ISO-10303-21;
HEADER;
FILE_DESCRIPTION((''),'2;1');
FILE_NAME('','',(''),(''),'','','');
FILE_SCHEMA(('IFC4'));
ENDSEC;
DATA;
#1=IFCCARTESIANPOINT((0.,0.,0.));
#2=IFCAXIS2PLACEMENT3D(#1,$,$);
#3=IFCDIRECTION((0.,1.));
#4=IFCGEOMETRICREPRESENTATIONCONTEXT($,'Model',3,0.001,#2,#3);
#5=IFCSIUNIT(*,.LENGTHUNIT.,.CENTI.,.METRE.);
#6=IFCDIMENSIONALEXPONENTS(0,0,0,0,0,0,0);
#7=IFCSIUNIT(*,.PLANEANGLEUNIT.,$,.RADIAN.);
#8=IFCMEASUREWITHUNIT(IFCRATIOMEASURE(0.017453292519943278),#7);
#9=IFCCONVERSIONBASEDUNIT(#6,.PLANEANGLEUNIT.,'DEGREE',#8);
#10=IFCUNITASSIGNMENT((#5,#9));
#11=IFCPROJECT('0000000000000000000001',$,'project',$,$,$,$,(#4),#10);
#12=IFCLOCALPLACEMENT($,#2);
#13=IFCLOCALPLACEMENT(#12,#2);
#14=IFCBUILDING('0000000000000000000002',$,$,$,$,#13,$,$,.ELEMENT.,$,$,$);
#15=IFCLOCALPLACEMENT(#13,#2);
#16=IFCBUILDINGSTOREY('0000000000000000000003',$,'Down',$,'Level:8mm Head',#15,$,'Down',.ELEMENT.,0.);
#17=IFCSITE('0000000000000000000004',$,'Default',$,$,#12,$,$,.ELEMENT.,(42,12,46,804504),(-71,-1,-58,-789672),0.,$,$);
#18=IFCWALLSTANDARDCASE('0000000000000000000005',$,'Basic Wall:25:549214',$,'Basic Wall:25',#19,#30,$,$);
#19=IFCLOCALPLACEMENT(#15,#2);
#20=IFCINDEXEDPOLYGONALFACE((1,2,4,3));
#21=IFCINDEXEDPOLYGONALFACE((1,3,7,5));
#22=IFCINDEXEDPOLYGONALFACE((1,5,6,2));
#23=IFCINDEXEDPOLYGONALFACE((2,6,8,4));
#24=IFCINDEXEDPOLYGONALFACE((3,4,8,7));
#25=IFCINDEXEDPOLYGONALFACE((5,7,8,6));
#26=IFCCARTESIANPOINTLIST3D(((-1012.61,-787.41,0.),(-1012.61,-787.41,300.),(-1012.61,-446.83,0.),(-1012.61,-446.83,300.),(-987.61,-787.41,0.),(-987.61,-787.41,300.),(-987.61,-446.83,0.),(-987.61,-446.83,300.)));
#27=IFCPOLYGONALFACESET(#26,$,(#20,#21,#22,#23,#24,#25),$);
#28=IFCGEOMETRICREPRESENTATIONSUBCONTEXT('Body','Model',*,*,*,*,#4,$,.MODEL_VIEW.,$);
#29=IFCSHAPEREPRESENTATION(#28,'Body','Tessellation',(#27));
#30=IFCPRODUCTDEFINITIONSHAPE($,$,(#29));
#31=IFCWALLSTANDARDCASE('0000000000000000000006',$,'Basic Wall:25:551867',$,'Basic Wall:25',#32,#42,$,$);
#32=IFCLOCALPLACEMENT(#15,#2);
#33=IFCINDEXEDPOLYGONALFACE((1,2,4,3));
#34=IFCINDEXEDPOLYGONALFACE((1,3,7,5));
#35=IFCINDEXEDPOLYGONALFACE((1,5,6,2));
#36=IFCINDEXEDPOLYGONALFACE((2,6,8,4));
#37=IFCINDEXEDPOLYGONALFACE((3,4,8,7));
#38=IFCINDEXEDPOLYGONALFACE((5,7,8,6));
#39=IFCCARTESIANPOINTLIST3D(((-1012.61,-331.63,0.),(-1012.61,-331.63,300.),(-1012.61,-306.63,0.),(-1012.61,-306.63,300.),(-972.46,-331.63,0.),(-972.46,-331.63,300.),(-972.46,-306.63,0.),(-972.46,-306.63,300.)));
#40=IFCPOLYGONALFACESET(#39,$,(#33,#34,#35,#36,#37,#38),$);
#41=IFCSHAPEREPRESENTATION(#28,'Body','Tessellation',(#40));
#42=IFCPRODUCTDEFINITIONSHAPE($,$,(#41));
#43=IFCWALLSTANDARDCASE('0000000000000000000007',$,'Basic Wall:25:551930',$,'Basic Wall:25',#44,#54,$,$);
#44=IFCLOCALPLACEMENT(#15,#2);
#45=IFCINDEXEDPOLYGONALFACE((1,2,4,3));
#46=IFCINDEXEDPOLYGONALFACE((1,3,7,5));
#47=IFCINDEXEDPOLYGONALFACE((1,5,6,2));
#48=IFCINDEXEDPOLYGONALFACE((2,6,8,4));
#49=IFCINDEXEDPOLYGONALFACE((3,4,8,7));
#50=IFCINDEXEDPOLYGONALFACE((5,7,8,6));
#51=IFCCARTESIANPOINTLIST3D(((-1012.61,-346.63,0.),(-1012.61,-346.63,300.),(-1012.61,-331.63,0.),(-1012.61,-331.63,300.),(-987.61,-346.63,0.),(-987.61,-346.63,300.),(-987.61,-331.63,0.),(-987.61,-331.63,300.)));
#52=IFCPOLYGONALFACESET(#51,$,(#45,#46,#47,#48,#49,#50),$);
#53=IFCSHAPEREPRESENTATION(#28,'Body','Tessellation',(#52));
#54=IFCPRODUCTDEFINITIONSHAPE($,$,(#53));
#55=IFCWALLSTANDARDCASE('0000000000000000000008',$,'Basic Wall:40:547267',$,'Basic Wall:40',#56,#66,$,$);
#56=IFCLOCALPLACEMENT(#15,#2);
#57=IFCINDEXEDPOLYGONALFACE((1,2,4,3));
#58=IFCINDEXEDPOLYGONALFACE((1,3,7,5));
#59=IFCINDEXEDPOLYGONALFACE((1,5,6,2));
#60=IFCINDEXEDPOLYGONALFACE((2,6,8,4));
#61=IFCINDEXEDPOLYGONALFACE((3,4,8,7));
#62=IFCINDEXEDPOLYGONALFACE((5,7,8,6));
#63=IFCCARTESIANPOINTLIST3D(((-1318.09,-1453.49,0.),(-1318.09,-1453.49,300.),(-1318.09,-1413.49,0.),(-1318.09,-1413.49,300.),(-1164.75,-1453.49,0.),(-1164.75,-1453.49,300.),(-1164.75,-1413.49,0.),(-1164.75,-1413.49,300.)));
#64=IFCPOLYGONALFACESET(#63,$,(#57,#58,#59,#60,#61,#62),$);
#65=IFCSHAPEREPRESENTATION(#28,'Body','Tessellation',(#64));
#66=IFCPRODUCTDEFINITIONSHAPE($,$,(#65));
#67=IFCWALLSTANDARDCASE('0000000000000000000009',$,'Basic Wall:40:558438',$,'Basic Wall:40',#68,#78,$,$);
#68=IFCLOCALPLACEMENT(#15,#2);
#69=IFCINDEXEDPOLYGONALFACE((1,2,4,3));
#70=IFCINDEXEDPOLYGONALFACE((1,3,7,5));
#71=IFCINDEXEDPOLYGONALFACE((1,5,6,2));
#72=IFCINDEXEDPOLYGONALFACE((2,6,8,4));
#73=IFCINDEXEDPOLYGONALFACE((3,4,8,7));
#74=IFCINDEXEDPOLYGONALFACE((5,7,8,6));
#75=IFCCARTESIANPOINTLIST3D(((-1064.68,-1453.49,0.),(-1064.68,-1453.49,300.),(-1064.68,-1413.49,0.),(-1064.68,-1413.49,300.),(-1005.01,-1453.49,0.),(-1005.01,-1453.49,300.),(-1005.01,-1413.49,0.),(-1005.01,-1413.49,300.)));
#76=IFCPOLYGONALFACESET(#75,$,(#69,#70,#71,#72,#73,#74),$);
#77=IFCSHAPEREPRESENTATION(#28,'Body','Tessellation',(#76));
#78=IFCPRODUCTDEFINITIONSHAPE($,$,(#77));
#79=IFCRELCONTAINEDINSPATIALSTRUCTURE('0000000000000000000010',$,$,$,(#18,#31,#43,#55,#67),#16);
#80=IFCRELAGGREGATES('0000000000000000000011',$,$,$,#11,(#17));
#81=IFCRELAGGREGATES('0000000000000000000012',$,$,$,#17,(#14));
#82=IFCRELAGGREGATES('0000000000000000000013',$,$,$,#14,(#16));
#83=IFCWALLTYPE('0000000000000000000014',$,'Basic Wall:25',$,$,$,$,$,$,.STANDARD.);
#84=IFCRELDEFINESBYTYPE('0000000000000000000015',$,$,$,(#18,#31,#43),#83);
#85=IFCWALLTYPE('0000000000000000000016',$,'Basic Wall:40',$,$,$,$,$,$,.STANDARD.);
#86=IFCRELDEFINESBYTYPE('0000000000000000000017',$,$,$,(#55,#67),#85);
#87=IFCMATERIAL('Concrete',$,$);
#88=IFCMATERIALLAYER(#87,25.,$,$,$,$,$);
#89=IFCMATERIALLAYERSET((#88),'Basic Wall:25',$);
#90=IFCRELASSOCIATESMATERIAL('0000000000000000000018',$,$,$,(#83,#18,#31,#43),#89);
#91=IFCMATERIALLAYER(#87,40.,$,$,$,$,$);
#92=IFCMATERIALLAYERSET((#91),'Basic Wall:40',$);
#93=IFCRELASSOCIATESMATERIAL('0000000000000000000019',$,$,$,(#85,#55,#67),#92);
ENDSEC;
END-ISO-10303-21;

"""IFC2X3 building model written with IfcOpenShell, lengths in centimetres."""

from ifc_helpers import new_model, entity, si_unit, converted_unit, direction, frame, frame_2d, origin, place, context, subcontext, project, spatial, rectangle, extrude, material, layer, layer_set, layer_usage, type_object, element, save


model = new_model("IFC2X3")

# Units and contexts
model_context = context("Model", 3, precision=0.001, world=origin(), true_north=direction((0.0, 1.0)))
body_context = subcontext(model_context, "Body", "Model", "MODEL_VIEW")
ifc_project = project(units=[si_unit("LENGTHUNIT", "METRE", prefix="CENTI"), converted_unit("PLANEANGLEUNIT", "DEGREE", entity("IfcRatioMeasure", 0.017453292519943278), si_unit("PLANEANGLEUNIT", "RADIAN"), dimensions=[0, 0, 0, 0, 0, 0, 0])], contexts=[model_context])

# Site, building, storey
site_placement = place(None, origin())
site = spatial("IfcSite", under=ifc_project, at=site_placement, Name="Default", CompositionType="ELEMENT", RefLatitude=(42, 12, 46, 804504), RefLongitude=(-71, -1, -58, -789672), RefElevation=0.0)
building_placement = place(site_placement, origin())
building = spatial("IfcBuilding", under=site, at=building_placement, CompositionType="ELEMENT")
storey_placement = place(building_placement, origin())
storey = spatial("IfcBuildingStorey", under=building, at=storey_placement, Name="Down", ObjectType="Level:8mm Head", LongName="Down", CompositionType="ELEMENT", Elevation=0.0)

# Walls
ifc_material = material(Name="Concrete")
ifc_layer_1 = layer(ifc_material, 25.0)
ifc_layer_set_1 = layer_set([ifc_layer_1], Name="Basic Wall:25")
wall_type_1 = type_object("IfcWallType", Name="Basic Wall:25", PredefinedType="STANDARD", material=ifc_layer_set_1)
ifc_layer_usage_1 = layer_usage(ifc_layer_set_1, "AXIS2", "POSITIVE", -12.5)
wall_1_placement = place(storey_placement, frame((-1000.11, -787.41, 0.0), z_axis=(0.0, 0.0, 1.0), x_axis=(0.0, 1.0, 0.0)))
element("IfcWallStandardCase", 1, at=wall_1_placement, inside=storey, type_object=wall_type_1, material=ifc_layer_usage_1, Name="Basic Wall:25:549214", ObjectType="Basic Wall:25", context=body_context, shape_type="SweptSolid", body=[
    extrude(rectangle(XDim=340.58, YDim=25.0, at=frame_2d((170.29, 0.0), x_axis=(-1.0, 0.0))), origin(), (0.0, 0.0, 1.0), 300.0),
])
ifc_layer_usage_2 = layer_usage(ifc_layer_set_1, "AXIS2", "NEGATIVE", 12.5)
wall_2_placement = place(storey_placement, frame((-972.46, -319.13, 0.0), z_axis=(0.0, 0.0, 1.0), x_axis=(-1.0, 0.0, 0.0)))
element("IfcWallStandardCase", 2, at=wall_2_placement, inside=storey, type_object=wall_type_1, material=ifc_layer_usage_2, Name="Basic Wall:25:551867", ObjectType="Basic Wall:25", context=body_context, shape_type="SweptSolid", body=[
    extrude(rectangle(XDim=40.15, YDim=25.0, at=frame_2d((20.07, 0.0), x_axis=(-1.0, 0.0))), origin(), (0.0, 0.0, 1.0), 300.0),
])
ifc_layer_usage_3 = layer_usage(ifc_layer_set_1, "AXIS2", "POSITIVE", -12.5)
wall_3_placement = place(storey_placement, frame((-1000.11, -331.63, 0.0), z_axis=(0.0, 0.0, 1.0), x_axis=(0.0, -1.0, 0.0)))
element("IfcWallStandardCase", 3, at=wall_3_placement, inside=storey, type_object=wall_type_1, material=ifc_layer_usage_3, Name="Basic Wall:25:551930", ObjectType="Basic Wall:25", context=body_context, shape_type="SweptSolid", body=[
    extrude(rectangle(XDim=15.0, YDim=25.0, at=frame_2d((7.5, 0.0), x_axis=(-1.0, 0.0))), origin(), (0.0, 0.0, 1.0), 300.0),
])
ifc_layer_2 = layer(ifc_material, 40.0)
ifc_layer_set_2 = layer_set([ifc_layer_2], Name="Basic Wall:40")
ifc_layer_usage_4 = layer_usage(ifc_layer_set_2, "AXIS2", "NEGATIVE", 20.0)
wall_type_2 = type_object("IfcWallType", Name="Basic Wall:40", PredefinedType="STANDARD", material=ifc_layer_set_2)
wall_4_placement = place(storey_placement, frame((-1164.75, -1433.49, 0.0), z_axis=(0.0, 0.0, 1.0), x_axis=(-1.0, 0.0, 0.0)))
element("IfcWallStandardCase", 4, at=wall_4_placement, inside=storey, type_object=wall_type_2, material=ifc_layer_usage_4, Name="Basic Wall:40:547267", ObjectType="Basic Wall:40", context=body_context, shape_type="SweptSolid", body=[
    extrude(rectangle(XDim=153.34, YDim=40.0, at=frame_2d((76.67, 0.0), x_axis=(-1.0, 0.0))), origin(), (0.0, 0.0, 1.0), 300.0),
])
ifc_layer_usage_5 = layer_usage(ifc_layer_set_2, "AXIS2", "POSITIVE", -20.0)
wall_5_placement = place(storey_placement, frame((-1064.68, -1433.49, 0.0)))
element("IfcWallStandardCase", 5, at=wall_5_placement, inside=storey, type_object=wall_type_2, material=ifc_layer_usage_5, Name="Basic Wall:40:558438", ObjectType="Basic Wall:40", context=body_context, shape_type="SweptSolid", body=[
    extrude(rectangle(XDim=59.68, YDim=40.0, at=frame_2d((29.84, 0.0), x_axis=(-1.0, 0.0))), origin(), (0.0, 0.0, 1.0), 300.0),
])

save(model, "model.ifc")
